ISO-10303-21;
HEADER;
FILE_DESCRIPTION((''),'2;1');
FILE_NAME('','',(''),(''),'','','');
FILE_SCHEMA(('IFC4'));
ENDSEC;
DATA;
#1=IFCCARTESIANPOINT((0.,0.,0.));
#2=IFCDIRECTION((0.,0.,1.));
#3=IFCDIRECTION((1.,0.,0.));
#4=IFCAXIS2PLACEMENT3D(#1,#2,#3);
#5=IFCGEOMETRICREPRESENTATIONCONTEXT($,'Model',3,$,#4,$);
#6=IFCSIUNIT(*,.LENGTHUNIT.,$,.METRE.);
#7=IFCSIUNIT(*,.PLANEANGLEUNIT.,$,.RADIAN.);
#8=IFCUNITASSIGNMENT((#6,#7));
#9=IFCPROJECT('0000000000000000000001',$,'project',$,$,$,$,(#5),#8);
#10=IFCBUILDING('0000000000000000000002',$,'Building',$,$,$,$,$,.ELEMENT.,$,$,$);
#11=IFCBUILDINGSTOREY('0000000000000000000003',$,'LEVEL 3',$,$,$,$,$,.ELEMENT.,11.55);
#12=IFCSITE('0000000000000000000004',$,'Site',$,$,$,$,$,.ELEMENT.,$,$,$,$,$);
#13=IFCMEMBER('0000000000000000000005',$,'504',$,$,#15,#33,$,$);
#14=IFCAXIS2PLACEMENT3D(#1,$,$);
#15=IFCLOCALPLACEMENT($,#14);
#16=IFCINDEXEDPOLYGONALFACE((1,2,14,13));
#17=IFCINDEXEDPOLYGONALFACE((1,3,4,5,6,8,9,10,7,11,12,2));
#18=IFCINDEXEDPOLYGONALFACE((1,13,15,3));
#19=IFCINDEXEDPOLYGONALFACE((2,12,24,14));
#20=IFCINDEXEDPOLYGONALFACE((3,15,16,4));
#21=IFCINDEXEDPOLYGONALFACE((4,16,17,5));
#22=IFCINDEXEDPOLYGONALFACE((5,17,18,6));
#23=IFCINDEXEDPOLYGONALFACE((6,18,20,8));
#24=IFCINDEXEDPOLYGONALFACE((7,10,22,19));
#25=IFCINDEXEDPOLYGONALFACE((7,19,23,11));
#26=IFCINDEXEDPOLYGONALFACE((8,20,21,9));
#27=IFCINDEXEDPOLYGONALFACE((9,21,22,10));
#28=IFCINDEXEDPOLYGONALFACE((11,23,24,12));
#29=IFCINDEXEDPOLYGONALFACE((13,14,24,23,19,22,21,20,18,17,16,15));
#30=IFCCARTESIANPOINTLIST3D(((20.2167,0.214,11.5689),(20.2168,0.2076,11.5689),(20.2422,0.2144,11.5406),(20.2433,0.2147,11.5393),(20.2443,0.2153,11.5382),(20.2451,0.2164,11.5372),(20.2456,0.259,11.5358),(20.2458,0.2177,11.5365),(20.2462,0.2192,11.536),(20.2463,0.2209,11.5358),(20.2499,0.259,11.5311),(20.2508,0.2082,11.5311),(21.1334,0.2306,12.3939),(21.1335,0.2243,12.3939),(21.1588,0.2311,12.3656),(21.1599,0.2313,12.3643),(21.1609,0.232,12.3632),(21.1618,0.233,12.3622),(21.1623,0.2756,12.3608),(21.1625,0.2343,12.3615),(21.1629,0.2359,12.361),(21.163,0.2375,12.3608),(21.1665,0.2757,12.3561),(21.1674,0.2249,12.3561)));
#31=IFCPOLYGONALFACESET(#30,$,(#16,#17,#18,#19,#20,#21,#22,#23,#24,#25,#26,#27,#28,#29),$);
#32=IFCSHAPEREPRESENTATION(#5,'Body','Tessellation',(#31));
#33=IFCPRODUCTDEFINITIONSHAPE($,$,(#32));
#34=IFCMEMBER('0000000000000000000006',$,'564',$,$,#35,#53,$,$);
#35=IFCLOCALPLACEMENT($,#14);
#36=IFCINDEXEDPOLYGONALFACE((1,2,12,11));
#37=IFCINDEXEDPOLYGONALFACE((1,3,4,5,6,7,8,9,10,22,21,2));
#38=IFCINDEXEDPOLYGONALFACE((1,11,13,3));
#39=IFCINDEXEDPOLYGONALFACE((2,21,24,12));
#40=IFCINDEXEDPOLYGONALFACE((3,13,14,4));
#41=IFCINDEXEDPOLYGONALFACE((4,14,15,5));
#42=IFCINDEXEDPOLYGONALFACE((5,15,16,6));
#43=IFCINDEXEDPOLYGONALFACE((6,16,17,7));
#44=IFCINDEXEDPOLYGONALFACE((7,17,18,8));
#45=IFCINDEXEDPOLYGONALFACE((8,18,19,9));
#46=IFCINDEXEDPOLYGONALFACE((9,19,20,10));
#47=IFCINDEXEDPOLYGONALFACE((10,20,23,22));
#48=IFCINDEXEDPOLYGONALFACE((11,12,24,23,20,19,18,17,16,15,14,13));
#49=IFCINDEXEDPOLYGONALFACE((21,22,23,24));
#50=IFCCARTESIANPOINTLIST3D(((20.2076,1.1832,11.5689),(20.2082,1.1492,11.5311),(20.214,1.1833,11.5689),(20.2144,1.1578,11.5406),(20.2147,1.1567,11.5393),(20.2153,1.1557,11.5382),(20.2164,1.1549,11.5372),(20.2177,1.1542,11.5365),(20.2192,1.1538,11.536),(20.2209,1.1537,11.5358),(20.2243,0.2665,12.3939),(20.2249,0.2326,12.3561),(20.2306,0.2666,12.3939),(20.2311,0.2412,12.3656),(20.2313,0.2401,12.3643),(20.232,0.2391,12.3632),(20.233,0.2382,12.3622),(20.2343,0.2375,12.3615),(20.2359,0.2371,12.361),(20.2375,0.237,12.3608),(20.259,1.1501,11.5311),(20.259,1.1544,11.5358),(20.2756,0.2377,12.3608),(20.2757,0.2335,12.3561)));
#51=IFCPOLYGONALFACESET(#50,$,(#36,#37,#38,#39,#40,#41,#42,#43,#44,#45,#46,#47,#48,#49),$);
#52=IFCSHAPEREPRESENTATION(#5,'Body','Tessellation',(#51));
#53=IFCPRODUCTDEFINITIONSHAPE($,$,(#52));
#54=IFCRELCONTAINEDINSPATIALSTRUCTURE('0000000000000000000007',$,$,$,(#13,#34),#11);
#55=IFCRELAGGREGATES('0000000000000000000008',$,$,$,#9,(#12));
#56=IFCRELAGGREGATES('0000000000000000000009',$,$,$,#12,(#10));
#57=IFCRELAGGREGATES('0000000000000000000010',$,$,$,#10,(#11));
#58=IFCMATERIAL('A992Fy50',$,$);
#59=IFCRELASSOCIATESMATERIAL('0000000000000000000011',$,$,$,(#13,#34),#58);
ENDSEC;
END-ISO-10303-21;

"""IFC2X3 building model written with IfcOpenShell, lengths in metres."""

from ifc_helpers import new_model, si_unit, frame, origin_with_axes, origin_2d_with_axis, place, context, project, spatial, l_section, extrude, material, element, save


model = new_model("IFC2X3")

# Units and contexts
model_context = context("Model", 3, world=origin_with_axes())
ifc_project = project(units=[si_unit("LENGTHUNIT", "METRE"), si_unit("PLANEANGLEUNIT", "RADIAN")], contexts=[model_context])

# Site, building, storey
site = spatial("IfcSite", under=ifc_project, Name="Site", CompositionType="ELEMENT")
building = spatial("IfcBuilding", under=site, Name="Building", CompositionType="ELEMENT")
storey = spatial("IfcBuildingStorey", under=building, Name="LEVEL 3", CompositionType="ELEMENT", Elevation=11.55)

# Shared definitions
ifc_material = material(Name="A992Fy50")

# Members
for number, where, z_axis, x_axis, name in (
    (1, (20.2333, 0.2333, 11.55), (0.743226, 0.013513, 0.668904), (-0.018179, 0.999835, 0.0), "504"),
    (2, (20.2333, 1.1667, 11.55), (0.013513, -0.743226, 0.668904), (0.999835, 0.018179, 0.0), "564"),
):
    element("IfcMember", number, at=place(None, frame(where, z_axis=z_axis, x_axis=x_axis)), inside=storey, material=ifc_material, Name=name, context=model_context, shape_type="SweptSolid", body=[
        extrude(l_section(Depth=0.0508, Width=0.0508, Thickness=0.0063, FilletRadius=0.0063, at=origin_2d_with_axis()), origin_with_axes(), (0.0, 0.0, 1.0), 1.2334),
    ])

save(model, "model.ifc")
